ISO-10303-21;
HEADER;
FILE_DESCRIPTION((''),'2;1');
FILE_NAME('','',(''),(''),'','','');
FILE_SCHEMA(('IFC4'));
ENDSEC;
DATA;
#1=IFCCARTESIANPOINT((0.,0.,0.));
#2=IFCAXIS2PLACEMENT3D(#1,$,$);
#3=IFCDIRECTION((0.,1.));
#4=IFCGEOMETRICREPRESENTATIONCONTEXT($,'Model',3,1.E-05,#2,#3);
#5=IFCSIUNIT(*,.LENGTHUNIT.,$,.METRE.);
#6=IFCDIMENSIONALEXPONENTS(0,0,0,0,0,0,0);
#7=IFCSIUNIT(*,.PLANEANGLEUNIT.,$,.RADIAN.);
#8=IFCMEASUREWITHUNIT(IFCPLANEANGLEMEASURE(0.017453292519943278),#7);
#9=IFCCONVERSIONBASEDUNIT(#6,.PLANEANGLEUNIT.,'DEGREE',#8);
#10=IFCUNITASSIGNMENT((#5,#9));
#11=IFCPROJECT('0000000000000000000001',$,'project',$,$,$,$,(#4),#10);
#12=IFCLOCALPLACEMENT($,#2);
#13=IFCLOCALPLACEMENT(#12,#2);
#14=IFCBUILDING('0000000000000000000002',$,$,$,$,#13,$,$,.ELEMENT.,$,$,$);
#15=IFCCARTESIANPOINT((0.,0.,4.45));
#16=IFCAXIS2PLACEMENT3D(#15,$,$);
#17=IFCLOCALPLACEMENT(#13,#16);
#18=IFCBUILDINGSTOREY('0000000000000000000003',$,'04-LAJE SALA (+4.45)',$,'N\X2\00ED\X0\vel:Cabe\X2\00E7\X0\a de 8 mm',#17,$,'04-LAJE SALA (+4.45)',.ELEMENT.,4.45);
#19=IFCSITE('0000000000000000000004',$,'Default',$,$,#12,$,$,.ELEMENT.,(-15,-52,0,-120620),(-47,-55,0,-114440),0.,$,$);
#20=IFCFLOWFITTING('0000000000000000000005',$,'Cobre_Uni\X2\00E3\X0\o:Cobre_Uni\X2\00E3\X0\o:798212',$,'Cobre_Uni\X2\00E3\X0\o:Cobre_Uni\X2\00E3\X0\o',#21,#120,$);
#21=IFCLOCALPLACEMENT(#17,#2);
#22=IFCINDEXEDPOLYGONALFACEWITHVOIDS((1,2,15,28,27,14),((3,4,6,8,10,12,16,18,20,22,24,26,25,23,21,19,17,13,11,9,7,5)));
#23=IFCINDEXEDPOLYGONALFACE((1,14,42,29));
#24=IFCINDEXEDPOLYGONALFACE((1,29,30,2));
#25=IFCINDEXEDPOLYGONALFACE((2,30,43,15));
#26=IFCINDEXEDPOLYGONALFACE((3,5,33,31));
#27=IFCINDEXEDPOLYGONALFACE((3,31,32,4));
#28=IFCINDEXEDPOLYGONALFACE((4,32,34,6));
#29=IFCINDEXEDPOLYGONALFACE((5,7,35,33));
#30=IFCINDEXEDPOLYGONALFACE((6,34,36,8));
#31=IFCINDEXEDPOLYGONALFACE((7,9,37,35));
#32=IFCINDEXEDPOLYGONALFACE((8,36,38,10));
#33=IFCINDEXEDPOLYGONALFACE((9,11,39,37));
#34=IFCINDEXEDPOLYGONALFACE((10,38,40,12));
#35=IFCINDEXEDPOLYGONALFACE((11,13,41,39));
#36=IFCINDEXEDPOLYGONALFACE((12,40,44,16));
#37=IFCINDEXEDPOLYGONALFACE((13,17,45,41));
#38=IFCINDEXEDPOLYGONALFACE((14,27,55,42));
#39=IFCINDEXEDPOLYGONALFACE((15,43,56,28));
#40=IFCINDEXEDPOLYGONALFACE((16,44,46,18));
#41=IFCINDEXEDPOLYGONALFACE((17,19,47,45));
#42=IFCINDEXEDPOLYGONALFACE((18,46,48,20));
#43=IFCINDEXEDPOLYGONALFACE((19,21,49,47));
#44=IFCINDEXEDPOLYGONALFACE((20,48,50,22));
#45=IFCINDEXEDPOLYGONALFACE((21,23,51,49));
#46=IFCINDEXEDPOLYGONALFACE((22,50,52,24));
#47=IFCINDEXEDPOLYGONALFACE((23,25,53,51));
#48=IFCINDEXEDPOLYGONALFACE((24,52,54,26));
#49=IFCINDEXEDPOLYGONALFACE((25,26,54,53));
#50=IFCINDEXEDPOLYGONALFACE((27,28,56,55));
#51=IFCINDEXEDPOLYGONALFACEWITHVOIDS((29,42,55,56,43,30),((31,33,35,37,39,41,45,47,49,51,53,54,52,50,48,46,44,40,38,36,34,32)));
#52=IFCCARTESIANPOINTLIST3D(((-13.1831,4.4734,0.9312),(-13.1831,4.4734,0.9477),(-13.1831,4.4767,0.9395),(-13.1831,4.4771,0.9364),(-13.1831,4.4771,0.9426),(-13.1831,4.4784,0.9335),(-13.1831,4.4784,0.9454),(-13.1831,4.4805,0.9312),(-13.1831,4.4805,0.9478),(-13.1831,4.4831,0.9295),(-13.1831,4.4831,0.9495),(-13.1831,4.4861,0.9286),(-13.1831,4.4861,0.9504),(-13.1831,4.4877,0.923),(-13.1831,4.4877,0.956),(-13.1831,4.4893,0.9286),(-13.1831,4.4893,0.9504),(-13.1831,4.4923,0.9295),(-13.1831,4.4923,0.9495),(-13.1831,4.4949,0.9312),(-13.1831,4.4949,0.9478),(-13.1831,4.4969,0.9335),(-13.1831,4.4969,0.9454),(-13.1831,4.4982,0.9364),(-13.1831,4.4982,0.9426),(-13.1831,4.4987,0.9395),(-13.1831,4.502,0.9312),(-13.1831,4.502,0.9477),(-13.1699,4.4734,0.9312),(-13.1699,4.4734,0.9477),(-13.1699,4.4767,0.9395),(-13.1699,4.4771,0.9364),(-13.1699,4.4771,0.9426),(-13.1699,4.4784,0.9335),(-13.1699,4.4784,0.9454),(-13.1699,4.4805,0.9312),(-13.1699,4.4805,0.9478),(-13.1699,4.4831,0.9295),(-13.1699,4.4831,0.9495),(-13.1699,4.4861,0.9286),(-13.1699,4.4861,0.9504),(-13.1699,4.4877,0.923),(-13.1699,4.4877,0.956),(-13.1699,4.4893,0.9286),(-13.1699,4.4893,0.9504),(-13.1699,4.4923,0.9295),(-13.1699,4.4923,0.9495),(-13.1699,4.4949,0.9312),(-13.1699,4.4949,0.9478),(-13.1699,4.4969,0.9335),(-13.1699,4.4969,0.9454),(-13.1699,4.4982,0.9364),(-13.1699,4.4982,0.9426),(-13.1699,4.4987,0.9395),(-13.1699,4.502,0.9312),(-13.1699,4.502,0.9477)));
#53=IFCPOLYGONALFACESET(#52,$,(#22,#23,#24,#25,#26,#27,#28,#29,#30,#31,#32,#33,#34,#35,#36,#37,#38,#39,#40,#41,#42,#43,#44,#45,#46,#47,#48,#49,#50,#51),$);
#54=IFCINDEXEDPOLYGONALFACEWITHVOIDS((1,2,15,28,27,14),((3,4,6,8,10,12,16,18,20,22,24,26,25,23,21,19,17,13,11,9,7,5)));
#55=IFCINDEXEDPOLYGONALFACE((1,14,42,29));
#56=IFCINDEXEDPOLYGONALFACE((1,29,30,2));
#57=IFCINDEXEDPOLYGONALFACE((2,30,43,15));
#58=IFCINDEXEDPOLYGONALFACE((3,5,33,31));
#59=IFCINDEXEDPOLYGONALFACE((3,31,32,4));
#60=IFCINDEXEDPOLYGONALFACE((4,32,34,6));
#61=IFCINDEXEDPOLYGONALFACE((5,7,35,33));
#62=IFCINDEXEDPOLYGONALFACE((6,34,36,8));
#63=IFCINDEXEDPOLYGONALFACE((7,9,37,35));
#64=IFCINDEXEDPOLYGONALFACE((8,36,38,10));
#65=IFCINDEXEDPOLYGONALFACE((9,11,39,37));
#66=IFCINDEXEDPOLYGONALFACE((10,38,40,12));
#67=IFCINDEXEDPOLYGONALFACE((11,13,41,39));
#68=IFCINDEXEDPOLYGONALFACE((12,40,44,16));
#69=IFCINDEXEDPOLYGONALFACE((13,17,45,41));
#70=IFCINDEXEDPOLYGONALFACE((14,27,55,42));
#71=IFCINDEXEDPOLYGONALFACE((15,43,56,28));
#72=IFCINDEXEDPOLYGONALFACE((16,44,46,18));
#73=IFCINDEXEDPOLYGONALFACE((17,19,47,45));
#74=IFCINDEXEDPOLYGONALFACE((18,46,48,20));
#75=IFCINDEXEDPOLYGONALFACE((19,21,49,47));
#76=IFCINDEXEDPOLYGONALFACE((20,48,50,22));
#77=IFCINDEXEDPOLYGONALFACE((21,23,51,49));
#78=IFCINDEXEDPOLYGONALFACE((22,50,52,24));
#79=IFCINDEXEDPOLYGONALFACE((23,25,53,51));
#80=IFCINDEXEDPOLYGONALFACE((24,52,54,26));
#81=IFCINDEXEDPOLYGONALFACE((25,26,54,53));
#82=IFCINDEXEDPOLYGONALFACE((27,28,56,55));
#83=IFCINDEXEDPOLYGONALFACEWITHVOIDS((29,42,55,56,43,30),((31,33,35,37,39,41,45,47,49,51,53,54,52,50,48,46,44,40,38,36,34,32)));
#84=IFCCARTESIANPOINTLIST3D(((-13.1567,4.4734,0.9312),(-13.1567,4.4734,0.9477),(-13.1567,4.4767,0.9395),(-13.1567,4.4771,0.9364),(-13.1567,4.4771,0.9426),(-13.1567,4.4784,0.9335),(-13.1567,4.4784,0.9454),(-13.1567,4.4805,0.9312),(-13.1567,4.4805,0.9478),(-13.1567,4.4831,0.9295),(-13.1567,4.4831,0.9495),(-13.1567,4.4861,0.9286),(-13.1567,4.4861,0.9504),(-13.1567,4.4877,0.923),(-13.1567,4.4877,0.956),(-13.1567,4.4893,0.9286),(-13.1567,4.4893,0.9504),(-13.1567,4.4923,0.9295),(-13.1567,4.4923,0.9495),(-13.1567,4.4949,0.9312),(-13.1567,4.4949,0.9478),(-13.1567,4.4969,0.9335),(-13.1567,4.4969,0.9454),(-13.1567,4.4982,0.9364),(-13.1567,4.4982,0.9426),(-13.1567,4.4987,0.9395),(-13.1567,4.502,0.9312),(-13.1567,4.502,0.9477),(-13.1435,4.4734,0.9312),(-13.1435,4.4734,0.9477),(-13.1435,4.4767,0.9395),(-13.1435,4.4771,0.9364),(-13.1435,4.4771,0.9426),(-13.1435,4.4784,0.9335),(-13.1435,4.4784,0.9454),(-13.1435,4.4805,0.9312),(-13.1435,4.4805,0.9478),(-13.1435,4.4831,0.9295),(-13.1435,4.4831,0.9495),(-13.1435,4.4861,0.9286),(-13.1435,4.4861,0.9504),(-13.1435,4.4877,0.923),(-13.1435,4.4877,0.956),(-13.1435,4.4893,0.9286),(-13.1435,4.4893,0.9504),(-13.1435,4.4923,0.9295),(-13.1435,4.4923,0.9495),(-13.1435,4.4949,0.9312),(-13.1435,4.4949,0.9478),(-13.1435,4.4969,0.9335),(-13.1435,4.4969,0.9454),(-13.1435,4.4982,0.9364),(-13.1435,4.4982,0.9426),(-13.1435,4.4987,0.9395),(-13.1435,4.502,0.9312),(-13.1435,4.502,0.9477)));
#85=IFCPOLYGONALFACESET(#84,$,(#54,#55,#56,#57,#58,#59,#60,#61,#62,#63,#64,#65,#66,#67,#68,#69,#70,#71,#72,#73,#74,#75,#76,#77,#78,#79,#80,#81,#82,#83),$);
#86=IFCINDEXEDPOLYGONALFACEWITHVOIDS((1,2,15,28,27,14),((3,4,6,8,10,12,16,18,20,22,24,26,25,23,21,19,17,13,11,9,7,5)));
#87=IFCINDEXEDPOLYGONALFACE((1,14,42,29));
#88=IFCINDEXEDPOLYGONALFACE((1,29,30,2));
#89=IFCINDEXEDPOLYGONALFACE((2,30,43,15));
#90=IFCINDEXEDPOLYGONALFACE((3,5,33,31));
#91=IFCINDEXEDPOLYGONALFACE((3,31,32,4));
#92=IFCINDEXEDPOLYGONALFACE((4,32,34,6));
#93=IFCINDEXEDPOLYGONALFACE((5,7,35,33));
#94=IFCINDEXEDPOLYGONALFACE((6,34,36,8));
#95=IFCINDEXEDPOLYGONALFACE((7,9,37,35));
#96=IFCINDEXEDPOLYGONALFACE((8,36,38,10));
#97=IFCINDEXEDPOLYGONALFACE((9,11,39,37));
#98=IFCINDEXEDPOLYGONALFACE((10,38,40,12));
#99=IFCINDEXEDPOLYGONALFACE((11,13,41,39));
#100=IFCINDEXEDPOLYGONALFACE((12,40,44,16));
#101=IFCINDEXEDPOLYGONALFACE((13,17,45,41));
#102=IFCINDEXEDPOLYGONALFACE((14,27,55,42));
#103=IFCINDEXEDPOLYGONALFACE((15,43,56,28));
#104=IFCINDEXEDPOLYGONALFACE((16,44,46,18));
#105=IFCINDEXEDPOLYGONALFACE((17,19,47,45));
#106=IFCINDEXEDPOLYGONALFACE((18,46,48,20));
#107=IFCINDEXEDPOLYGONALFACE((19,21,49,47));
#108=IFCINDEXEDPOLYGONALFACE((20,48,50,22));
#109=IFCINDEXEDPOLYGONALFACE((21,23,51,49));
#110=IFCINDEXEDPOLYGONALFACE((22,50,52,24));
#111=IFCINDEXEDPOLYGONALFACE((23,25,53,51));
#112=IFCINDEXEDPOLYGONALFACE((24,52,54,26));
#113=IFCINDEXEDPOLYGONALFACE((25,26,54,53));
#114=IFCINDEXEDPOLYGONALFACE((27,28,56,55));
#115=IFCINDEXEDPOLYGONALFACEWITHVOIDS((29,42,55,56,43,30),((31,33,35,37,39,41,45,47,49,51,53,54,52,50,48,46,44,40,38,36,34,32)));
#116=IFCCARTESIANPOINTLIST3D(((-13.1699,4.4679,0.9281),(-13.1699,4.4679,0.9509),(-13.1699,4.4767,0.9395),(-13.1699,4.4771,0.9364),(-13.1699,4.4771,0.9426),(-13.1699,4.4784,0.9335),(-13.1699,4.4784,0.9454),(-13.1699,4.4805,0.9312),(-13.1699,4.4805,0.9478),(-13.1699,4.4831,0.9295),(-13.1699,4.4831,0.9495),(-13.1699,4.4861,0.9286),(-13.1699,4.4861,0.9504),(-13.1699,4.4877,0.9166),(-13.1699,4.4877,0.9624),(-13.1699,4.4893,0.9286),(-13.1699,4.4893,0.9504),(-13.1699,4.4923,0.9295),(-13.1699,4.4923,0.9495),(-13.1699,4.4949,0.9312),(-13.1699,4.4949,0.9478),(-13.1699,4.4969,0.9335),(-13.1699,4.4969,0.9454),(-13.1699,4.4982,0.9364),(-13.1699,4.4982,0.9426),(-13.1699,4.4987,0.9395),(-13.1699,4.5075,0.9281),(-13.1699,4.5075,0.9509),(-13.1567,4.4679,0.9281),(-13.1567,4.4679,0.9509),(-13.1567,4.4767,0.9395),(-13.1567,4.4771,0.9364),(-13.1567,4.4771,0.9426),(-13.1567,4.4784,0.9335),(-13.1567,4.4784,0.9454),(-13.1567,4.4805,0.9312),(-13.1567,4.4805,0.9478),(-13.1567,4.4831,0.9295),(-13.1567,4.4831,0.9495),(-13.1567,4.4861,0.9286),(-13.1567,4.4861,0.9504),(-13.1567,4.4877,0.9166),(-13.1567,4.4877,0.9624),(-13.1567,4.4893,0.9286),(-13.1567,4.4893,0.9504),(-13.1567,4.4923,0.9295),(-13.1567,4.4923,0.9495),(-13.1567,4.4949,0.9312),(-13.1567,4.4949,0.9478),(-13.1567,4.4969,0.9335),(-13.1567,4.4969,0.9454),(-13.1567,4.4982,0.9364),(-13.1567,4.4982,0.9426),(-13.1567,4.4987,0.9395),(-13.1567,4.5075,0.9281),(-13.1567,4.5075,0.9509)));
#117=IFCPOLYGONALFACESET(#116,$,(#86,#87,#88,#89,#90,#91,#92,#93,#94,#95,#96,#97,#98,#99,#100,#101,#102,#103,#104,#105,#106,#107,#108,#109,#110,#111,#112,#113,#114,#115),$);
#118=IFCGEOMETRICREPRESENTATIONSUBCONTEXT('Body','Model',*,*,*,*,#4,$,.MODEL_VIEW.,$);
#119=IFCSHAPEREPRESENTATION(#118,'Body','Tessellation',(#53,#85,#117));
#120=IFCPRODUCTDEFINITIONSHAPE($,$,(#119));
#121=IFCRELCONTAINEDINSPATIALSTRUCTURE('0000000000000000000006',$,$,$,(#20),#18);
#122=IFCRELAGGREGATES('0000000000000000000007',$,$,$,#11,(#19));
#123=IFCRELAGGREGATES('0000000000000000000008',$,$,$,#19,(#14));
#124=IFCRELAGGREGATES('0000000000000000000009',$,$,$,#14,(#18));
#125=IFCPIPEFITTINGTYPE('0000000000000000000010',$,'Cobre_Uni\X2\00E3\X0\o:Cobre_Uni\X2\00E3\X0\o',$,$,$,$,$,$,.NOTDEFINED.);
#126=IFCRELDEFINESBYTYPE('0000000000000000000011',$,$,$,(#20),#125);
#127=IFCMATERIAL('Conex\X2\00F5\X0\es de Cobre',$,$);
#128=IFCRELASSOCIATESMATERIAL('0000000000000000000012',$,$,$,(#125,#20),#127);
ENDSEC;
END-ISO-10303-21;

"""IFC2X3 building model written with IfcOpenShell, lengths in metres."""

from ifc_helpers import new_model, entity, si_unit, converted_unit, direction, frame, frame_2d, origin, place, context, subcontext, project, spatial, polyline, circle_curve, parameter, trimmed, segment, composite_curve, outline, extrude, source, transform, mapped, material, type_object, type_shapes, element, save


model = new_model("IFC2X3")

# Units and contexts
model_context = context("Model", 3, precision=1e-05, world=origin(), true_north=direction((0.0, 1.0)))
body_context = subcontext(model_context, "Body", "Model", "MODEL_VIEW")
ifc_project = project(units=[si_unit("LENGTHUNIT", "METRE"), converted_unit("PLANEANGLEUNIT", "DEGREE", entity("IfcPlaneAngleMeasure", 0.017453292519943278), si_unit("PLANEANGLEUNIT", "RADIAN"), dimensions=[0, 0, 0, 0, 0, 0, 0])], contexts=[model_context])

# Site, building, storey
site_placement = place(None, origin())
site = spatial("IfcSite", under=ifc_project, at=site_placement, Name="Default", CompositionType="ELEMENT", RefLatitude=(-15, -52, 0, -120620), RefLongitude=(-47, -55, 0, -114440), RefElevation=0.0)
building_placement = place(site_placement, origin())
building = spatial("IfcBuilding", under=site, at=building_placement, CompositionType="ELEMENT")
storey_placement = place(building_placement, frame((0.0, 0.0, 4.45)))
storey = spatial("IfcBuildingStorey", under=building, at=storey_placement, Name="04-LAJE SALA (+4.45)", ObjectType="Nível:Cabeça de 8 mm", LongName="04-LAJE SALA (+4.45)", CompositionType="ELEMENT", Elevation=4.45)

# Flow fitting
ifc_material_1 = material(Name="Conexões de Cobre")
pipe_fitting_type_1 = type_object("IfcPipeFittingType", Name="Cobre_União:Cobre_União", PredefinedType="NOTDEFINED", material=ifc_material_1)
shared_shape_1 = source(origin(), body_context, "Body", "SweptSolid", [
    extrude(outline(polyline([(-0.0083, -0.0143), (0.0083, -0.0143), (0.0165, 0.0), (0.0083, 0.0143), (-0.0083, 0.0143), (-0.0165, 0.0), (-0.0083, -0.0143)]), holes=[composite_curve([segment(trimmed(circle_curve(frame_2d((0.0, 0.0), x_axis=(0.0, 1.0)), 0.011), [parameter(0.0)], [parameter(180.0)], True, "PARAMETER"), False, "CONTINUOUS"), segment(trimmed(circle_curve(frame_2d((0.0, 0.0), x_axis=(0.0, 1.0)), 0.011), [parameter(180.0)], [parameter(0.0)], True, "PARAMETER"), False, "CONTINUOUS")], self_intersect=False)]), frame((0.0264, 0.0, 0.0), z_axis=(1.0, 0.0, 0.0), x_axis=(0.0, 0.0, -1.0)), (0.0, 0.0, 1.0), 0.0132),
    extrude(outline(polyline([(-0.0083, -0.0143), (0.0083, -0.0143), (0.0165, 0.0), (0.0083, 0.0143), (-0.0083, 0.0143), (-0.0165, 0.0), (-0.0083, -0.0143)]), holes=[composite_curve([segment(trimmed(circle_curve(frame_2d((0.0, 0.0), x_axis=(0.0, 1.0)), 0.011), [parameter(0.0)], [parameter(180.0)], True, "PARAMETER"), False, "CONTINUOUS"), segment(trimmed(circle_curve(frame_2d((0.0, 0.0), x_axis=(0.0, 1.0)), 0.011), [parameter(180.0)], [parameter(0.0)], True, "PARAMETER"), False, "CONTINUOUS")], self_intersect=False)]), frame((0.0, 0.0, 0.0), z_axis=(1.0, 0.0, 0.0), x_axis=(0.0, 0.0, -1.0)), (0.0, 0.0, 1.0), 0.0132),
    extrude(outline(polyline([(-0.0114, -0.0198), (0.0114, -0.0198), (0.0229, 0.0), (0.0114, 0.0198), (-0.0114, 0.0198), (-0.0229, 0.0), (-0.0114, -0.0198)]), holes=[composite_curve([segment(trimmed(circle_curve(frame_2d((0.0, 0.0), x_axis=(0.0, 1.0)), 0.011), [parameter(0.0)], [parameter(180.0)], True, "PARAMETER"), False, "CONTINUOUS"), segment(trimmed(circle_curve(frame_2d((0.0, 0.0), x_axis=(0.0, 1.0)), 0.011), [parameter(180.0)], [parameter(0.0)], True, "PARAMETER"), False, "CONTINUOUS")], self_intersect=False)]), frame((0.0132, 0.0, 0.0), z_axis=(1.0, 0.0, 0.0), x_axis=(0.0, 0.0, -1.0)), (0.0, 0.0, 1.0), 0.0132),
])
type_shapes(pipe_fitting_type_1, [shared_shape_1])
flow_fitting_1_placement = place(storey_placement, frame((-13.1435, 4.4877, 0.9395), z_axis=(-0.000008, 0.0, 1.0), x_axis=(-1.0, 0.0, -0.000008)))
element("IfcFlowFitting", 1, at=flow_fitting_1_placement, inside=storey, type_object=pipe_fitting_type_1, material=ifc_material_1, Name="Cobre_União:Cobre_União:798212", ObjectType="Cobre_União:Cobre_União", context=body_context, shape_type="MappedRepresentation", body=[
    mapped(shared_shape_1, transform((0.0, 0.0, 0.0), scale=1.0)),
])

save(model, "model.ifc")
